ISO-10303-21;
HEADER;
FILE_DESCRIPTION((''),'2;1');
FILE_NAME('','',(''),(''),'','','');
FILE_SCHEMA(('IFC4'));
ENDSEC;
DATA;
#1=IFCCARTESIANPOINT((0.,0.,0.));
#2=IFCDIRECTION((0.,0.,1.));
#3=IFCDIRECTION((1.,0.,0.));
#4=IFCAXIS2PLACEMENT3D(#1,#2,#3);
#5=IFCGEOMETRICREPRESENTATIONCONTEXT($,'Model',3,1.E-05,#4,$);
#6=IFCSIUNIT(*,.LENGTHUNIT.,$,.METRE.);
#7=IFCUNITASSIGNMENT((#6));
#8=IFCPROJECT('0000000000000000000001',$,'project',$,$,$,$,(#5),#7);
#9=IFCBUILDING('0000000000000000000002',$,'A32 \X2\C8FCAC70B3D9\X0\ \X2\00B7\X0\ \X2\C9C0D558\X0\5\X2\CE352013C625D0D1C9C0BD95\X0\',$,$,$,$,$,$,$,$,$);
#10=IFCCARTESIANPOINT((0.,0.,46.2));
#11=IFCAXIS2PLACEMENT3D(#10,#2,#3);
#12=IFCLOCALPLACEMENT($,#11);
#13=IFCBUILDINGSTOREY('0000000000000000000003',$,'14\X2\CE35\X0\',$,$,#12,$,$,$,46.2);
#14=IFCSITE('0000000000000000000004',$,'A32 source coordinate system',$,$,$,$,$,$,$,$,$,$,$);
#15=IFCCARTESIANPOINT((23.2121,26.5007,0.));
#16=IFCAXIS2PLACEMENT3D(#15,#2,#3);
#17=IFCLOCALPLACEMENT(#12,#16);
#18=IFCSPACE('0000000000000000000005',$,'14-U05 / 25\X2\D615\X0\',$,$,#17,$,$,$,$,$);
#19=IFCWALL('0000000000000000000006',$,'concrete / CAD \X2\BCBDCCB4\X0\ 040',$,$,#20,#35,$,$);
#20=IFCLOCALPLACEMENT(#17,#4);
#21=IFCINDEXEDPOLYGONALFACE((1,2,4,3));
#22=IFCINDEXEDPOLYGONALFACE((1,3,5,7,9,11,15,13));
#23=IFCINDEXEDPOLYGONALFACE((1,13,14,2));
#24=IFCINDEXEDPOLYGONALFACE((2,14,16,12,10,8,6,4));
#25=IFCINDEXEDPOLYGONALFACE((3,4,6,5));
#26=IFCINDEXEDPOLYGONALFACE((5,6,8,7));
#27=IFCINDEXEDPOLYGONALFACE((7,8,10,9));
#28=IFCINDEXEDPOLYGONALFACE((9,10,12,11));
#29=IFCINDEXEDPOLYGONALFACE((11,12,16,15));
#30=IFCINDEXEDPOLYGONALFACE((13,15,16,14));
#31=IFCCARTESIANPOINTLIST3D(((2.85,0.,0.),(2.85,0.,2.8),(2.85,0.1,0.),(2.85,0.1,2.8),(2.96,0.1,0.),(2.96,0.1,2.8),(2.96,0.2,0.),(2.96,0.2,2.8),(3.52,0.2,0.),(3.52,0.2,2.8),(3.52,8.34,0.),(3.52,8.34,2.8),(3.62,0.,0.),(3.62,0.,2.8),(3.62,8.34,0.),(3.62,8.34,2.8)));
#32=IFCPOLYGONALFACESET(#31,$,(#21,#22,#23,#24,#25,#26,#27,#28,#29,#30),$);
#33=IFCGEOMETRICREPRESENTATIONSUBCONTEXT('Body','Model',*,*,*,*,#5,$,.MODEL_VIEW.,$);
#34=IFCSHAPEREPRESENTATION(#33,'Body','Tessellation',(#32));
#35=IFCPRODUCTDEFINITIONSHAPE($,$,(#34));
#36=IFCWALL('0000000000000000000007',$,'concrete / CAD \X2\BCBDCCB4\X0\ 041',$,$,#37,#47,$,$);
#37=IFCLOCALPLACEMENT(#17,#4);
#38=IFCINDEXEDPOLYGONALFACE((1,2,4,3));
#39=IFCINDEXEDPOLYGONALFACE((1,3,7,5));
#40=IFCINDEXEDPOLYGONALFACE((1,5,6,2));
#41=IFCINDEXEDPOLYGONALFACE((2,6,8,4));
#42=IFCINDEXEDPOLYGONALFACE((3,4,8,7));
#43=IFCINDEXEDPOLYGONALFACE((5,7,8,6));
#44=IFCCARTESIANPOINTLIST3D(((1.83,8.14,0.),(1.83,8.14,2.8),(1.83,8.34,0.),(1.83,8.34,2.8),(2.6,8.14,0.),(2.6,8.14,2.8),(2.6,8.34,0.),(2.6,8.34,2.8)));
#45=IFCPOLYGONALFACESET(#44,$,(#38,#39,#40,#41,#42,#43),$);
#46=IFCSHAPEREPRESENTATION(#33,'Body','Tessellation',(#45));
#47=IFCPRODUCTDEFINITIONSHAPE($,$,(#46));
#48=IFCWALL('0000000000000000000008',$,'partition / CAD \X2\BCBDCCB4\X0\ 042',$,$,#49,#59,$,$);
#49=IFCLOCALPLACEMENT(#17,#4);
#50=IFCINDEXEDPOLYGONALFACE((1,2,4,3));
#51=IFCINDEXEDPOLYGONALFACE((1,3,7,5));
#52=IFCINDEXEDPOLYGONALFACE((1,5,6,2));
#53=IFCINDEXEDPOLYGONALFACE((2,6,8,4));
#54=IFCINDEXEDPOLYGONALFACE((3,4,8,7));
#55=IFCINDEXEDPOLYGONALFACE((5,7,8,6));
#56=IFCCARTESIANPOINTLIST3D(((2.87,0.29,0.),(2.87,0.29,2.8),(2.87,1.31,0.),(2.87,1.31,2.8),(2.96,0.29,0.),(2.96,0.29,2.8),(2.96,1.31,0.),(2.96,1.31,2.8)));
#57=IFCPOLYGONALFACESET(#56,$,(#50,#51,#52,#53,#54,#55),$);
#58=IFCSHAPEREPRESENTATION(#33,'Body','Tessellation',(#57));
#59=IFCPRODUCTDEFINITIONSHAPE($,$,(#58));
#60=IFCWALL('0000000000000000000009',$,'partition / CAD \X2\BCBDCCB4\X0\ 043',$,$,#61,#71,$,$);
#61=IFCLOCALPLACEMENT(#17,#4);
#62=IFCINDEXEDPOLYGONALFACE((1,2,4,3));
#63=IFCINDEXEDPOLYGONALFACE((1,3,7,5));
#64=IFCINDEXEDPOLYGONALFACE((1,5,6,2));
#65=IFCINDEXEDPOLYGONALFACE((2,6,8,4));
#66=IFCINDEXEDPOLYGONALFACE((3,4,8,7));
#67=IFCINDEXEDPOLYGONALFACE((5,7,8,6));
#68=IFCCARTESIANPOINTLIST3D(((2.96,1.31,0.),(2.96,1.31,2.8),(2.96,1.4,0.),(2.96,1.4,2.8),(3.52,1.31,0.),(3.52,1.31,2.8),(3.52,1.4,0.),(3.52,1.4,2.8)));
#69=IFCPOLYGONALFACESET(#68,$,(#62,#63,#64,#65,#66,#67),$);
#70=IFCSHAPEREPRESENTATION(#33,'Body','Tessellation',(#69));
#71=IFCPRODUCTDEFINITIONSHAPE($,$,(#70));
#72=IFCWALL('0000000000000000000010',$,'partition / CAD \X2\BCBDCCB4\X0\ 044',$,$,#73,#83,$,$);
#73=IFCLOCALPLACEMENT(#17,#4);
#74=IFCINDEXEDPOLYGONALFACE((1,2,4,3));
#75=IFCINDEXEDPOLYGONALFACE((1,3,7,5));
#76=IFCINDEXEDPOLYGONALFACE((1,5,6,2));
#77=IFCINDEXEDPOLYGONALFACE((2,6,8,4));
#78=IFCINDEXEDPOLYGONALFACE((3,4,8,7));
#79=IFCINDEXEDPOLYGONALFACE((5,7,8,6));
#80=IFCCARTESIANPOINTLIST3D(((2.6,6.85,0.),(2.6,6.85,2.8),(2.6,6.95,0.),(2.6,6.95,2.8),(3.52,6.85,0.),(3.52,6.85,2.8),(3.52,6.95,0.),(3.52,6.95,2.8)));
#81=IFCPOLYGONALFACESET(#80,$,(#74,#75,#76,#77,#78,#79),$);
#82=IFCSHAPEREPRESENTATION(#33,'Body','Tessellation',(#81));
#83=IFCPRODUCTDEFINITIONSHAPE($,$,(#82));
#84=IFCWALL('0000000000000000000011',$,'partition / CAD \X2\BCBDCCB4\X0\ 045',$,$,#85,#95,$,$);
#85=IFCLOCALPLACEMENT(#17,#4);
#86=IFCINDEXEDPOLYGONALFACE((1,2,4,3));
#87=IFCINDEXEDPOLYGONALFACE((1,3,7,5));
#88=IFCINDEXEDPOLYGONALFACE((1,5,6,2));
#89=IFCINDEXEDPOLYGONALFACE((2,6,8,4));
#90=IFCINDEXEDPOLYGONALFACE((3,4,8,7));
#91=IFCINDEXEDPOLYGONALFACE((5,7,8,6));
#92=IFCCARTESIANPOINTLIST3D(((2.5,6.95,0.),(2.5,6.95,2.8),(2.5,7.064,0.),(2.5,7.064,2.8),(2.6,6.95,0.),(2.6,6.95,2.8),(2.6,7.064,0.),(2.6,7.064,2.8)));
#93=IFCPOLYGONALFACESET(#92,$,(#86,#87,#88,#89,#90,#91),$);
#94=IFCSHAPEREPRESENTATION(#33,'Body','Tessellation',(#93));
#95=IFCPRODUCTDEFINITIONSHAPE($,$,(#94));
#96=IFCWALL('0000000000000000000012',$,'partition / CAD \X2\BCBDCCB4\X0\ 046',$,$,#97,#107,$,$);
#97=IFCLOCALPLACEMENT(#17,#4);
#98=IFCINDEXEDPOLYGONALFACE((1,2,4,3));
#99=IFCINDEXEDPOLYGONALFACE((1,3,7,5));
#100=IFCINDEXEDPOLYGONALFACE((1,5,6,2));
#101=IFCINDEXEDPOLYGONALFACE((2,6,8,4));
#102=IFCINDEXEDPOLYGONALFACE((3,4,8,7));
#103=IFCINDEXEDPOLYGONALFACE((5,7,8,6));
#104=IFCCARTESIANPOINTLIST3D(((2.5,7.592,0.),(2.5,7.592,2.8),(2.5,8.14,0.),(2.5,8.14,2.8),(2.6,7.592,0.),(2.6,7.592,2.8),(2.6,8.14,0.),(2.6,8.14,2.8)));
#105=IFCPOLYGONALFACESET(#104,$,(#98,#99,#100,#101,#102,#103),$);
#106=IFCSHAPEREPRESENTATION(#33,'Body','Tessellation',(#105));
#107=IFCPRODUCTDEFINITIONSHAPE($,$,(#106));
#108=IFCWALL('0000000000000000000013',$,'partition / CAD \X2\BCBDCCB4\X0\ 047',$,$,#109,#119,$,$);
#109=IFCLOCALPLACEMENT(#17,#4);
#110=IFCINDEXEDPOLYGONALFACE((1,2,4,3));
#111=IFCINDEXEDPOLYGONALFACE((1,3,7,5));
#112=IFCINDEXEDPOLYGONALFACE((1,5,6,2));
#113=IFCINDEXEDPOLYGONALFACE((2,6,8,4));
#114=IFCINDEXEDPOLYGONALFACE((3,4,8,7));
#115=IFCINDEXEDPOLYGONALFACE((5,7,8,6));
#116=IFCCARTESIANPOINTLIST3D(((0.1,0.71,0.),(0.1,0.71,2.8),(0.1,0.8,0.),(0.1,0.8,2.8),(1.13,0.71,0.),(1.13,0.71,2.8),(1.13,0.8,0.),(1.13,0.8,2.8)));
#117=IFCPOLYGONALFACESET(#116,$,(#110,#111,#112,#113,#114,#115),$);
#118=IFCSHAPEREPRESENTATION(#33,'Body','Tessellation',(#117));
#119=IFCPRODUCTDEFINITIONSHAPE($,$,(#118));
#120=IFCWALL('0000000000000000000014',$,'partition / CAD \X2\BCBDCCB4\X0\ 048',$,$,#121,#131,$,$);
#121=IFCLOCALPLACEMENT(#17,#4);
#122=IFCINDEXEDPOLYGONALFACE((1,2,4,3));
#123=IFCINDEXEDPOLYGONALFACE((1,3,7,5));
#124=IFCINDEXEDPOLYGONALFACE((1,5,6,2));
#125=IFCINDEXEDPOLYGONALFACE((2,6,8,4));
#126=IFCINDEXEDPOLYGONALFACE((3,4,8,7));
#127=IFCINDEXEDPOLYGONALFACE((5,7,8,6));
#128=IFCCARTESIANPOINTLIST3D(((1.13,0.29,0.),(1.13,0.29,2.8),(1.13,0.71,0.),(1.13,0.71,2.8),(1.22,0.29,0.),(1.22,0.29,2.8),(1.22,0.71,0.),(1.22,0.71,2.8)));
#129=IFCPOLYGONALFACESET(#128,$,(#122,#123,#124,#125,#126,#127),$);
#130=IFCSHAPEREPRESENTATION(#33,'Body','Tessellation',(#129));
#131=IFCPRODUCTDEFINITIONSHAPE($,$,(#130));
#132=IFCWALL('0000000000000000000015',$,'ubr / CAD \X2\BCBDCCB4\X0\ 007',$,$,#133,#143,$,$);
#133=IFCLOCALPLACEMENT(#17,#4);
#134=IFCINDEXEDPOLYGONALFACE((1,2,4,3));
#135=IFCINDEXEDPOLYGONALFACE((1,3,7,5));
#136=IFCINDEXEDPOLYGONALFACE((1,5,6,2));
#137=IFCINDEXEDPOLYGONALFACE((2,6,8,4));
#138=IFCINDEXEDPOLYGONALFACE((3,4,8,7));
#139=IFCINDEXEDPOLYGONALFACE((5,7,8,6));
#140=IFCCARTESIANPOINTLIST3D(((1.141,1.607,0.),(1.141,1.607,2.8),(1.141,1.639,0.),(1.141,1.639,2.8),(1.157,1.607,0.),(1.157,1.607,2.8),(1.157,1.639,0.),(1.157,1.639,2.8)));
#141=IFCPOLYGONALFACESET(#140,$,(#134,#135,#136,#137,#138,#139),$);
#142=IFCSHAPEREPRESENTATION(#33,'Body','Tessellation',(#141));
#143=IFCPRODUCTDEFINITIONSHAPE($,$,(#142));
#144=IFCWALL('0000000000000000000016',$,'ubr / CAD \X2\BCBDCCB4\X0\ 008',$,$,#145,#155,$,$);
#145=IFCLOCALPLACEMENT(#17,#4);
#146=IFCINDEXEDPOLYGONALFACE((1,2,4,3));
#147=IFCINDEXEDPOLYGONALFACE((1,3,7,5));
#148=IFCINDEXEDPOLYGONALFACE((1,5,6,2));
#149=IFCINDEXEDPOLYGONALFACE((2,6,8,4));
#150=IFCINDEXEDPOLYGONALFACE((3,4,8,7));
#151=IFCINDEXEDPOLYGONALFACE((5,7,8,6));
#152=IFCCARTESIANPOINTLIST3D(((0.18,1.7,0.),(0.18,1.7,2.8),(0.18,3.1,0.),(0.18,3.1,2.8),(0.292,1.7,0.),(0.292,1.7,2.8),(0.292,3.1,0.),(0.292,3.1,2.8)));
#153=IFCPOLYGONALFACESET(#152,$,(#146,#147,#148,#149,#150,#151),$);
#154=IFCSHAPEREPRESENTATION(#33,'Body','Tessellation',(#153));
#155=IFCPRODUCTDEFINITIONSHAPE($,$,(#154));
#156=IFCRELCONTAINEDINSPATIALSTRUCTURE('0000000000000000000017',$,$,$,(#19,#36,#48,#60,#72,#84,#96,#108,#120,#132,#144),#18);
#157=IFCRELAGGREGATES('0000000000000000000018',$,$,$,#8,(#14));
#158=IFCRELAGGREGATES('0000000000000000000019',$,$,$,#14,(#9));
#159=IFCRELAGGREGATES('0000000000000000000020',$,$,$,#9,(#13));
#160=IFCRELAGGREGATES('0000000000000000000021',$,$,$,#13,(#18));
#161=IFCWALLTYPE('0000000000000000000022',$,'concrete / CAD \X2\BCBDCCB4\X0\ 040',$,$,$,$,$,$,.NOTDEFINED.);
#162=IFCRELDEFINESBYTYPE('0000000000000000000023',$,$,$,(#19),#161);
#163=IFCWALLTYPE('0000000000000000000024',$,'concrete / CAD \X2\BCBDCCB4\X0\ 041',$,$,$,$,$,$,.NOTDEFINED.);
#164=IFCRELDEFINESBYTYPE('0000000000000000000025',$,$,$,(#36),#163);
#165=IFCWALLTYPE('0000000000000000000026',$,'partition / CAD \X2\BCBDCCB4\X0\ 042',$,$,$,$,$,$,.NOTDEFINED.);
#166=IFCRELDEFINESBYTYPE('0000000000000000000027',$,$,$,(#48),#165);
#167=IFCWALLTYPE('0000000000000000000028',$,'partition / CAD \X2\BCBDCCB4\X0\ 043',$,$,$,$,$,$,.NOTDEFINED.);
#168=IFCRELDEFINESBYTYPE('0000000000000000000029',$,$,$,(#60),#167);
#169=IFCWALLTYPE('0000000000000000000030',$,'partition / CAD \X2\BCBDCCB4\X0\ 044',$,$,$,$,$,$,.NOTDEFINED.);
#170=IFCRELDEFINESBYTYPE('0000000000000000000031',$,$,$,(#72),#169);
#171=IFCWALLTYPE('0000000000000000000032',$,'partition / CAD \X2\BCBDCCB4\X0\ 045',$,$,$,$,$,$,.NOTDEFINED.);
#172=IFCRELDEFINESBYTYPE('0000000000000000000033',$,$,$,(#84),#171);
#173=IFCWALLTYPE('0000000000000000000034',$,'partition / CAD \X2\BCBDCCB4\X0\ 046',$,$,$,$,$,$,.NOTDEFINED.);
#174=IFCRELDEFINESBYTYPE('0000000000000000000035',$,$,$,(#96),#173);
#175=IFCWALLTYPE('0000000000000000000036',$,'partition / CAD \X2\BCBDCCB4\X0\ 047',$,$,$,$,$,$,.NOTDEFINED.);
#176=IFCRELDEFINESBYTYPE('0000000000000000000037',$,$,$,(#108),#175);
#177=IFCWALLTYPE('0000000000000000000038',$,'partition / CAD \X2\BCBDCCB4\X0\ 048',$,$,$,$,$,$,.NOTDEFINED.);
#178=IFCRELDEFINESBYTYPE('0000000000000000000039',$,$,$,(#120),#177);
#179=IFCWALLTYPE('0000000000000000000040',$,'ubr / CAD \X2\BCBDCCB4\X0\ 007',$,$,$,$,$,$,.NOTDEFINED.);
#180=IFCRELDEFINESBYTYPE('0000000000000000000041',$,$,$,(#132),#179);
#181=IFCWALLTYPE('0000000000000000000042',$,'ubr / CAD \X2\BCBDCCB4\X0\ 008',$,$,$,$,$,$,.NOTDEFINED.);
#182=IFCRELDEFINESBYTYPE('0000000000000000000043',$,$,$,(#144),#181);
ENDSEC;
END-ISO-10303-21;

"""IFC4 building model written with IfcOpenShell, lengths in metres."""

from ifc_helpers import new_model, si_unit, frame, origin, origin_with_axes, place, context, subcontext, project, spatial, polyline, outline, extrude, source, transform, mapped, type_object, type_shapes, element, save


model = new_model("IFC4")

# Units and contexts
model_context = context("Model", 3, precision=1e-05, world=origin_with_axes())
body_context = subcontext(model_context, "Body", "Model", "MODEL_VIEW")
ifc_project = project(units=[si_unit("LENGTHUNIT", "METRE")], contexts=[model_context])

# Site, building, storey, space
site = spatial("IfcSite", under=ifc_project, Name="A32 source coordinate system")
building = spatial("IfcBuilding", under=site, Name="A32 주거동 · 지하5층–옥탑지붕")
storey_placement = place(None, frame((0.0, 0.0, 46.2), z_axis=(0.0, 0.0, 1.0), x_axis=(1.0, 0.0, 0.0)))
storey = spatial("IfcBuildingStorey", under=building, at=storey_placement, Name="14층", Elevation=46.2)
space_1_placement = place(storey_placement, frame((23.2121, 26.5007, 0.0), z_axis=(0.0, 0.0, 1.0), x_axis=(1.0, 0.0, 0.0)))
space_1 = spatial("IfcSpace", under=storey, at=space_1_placement, Name="14-U05 / 25형")

# Walls
wall_type_1 = type_object("IfcWallType", Name="concrete / CAD 벽체 040", PredefinedType="NOTDEFINED")
shared_shape_1 = source(origin(), body_context, "Body", "SweptSolid", [
    extrude(outline(polyline([(3.62, 8.34), (3.62, 0.0), (2.85, 0.0), (2.85, 0.1), (2.96, 0.1), (2.96, 0.2), (3.52, 0.2), (3.52, 8.34), (3.62, 8.34)])), origin(), (0.0, 0.0, 1.0), 2.8),
])
type_shapes(wall_type_1, [shared_shape_1])
wall_1_placement = place(space_1_placement, origin_with_axes())
element("IfcWall", 1, at=wall_1_placement, inside=space_1, type_object=wall_type_1, Name="concrete / CAD 벽체 040", context=body_context, shape_type="MappedRepresentation", body=[
    mapped(shared_shape_1, transform((0.0, 0.0, 0.0), scale=1.0)),
])
wall_type_2 = type_object("IfcWallType", Name="concrete / CAD 벽체 041", PredefinedType="NOTDEFINED")
shared_shape_2 = source(origin(), body_context, "Body", "SweptSolid", [
    extrude(outline(polyline([(2.6, 8.14), (1.83, 8.14), (1.83, 8.34), (2.6, 8.34), (2.6, 8.14)])), origin(), (0.0, 0.0, 1.0), 2.8),
])
type_shapes(wall_type_2, [shared_shape_2])
wall_2_placement = place(space_1_placement, origin_with_axes())
element("IfcWall", 2, at=wall_2_placement, inside=space_1, type_object=wall_type_2, Name="concrete / CAD 벽체 041", context=body_context, shape_type="MappedRepresentation", body=[
    mapped(shared_shape_2, transform((0.0, 0.0, 0.0), scale=1.0)),
])
wall_type_3 = type_object("IfcWallType", Name="partition / CAD 벽체 042", PredefinedType="NOTDEFINED")
shared_shape_3 = source(origin(), body_context, "Body", "SweptSolid", [
    extrude(outline(polyline([(2.87, 1.31), (2.96, 1.31), (2.96, 0.29), (2.87, 0.29), (2.87, 1.31)])), origin(), (0.0, 0.0, 1.0), 2.8),
])
type_shapes(wall_type_3, [shared_shape_3])
wall_3_placement = place(space_1_placement, origin_with_axes())
element("IfcWall", 3, at=wall_3_placement, inside=space_1, type_object=wall_type_3, Name="partition / CAD 벽체 042", context=body_context, shape_type="MappedRepresentation", body=[
    mapped(shared_shape_3, transform((0.0, 0.0, 0.0), scale=1.0)),
])
wall_type_4 = type_object("IfcWallType", Name="partition / CAD 벽체 043", PredefinedType="NOTDEFINED")
shared_shape_4 = source(origin(), body_context, "Body", "SweptSolid", [
    extrude(outline(polyline([(3.52, 1.4), (3.52, 1.31), (2.96, 1.31), (2.96, 1.4), (3.52, 1.4)])), origin(), (0.0, 0.0, 1.0), 2.8),
])
type_shapes(wall_type_4, [shared_shape_4])
wall_4_placement = place(space_1_placement, origin_with_axes())
element("IfcWall", 4, at=wall_4_placement, inside=space_1, type_object=wall_type_4, Name="partition / CAD 벽체 043", context=body_context, shape_type="MappedRepresentation", body=[
    mapped(shared_shape_4, transform((0.0, 0.0, 0.0), scale=1.0)),
])
wall_type_5 = type_object("IfcWallType", Name="partition / CAD 벽체 044", PredefinedType="NOTDEFINED")
shared_shape_5 = source(origin(), body_context, "Body", "SweptSolid", [
    extrude(outline(polyline([(3.52, 6.95), (3.52, 6.85), (2.6, 6.85), (2.6, 6.95), (3.52, 6.95)])), origin(), (0.0, 0.0, 1.0), 2.8),
])
type_shapes(wall_type_5, [shared_shape_5])
wall_5_placement = place(space_1_placement, origin_with_axes())
element("IfcWall", 5, at=wall_5_placement, inside=space_1, type_object=wall_type_5, Name="partition / CAD 벽체 044", context=body_context, shape_type="MappedRepresentation", body=[
    mapped(shared_shape_5, transform((0.0, 0.0, 0.0), scale=1.0)),
])
wall_type_6 = type_object("IfcWallType", Name="partition / CAD 벽체 045", PredefinedType="NOTDEFINED")
shared_shape_6 = source(origin(), body_context, "Body", "SweptSolid", [
    extrude(outline(polyline([(2.5, 7.064), (2.6, 7.064), (2.6, 6.95), (2.5, 6.95), (2.5, 7.064)])), origin(), (0.0, 0.0, 1.0), 2.8),
])
type_shapes(wall_type_6, [shared_shape_6])
wall_6_placement = place(space_1_placement, origin_with_axes())
element("IfcWall", 6, at=wall_6_placement, inside=space_1, type_object=wall_type_6, Name="partition / CAD 벽체 045", context=body_context, shape_type="MappedRepresentation", body=[
    mapped(shared_shape_6, transform((0.0, 0.0, 0.0), scale=1.0)),
])
wall_type_7 = type_object("IfcWallType", Name="partition / CAD 벽체 046", PredefinedType="NOTDEFINED")
shared_shape_7 = source(origin(), body_context, "Body", "SweptSolid", [
    extrude(outline(polyline([(2.6, 7.592), (2.5, 7.592), (2.5, 8.14), (2.6, 8.14), (2.6, 7.592)])), origin(), (0.0, 0.0, 1.0), 2.8),
])
type_shapes(wall_type_7, [shared_shape_7])
wall_7_placement = place(space_1_placement, origin_with_axes())
element("IfcWall", 7, at=wall_7_placement, inside=space_1, type_object=wall_type_7, Name="partition / CAD 벽체 046", context=body_context, shape_type="MappedRepresentation", body=[
    mapped(shared_shape_7, transform((0.0, 0.0, 0.0), scale=1.0)),
])
wall_type_8 = type_object("IfcWallType", Name="partition / CAD 벽체 047", PredefinedType="NOTDEFINED")
shared_shape_8 = source(origin(), body_context, "Body", "SweptSolid", [
    extrude(outline(polyline([(1.13, 0.71), (0.1, 0.71), (0.1, 0.8), (1.13, 0.8), (1.13, 0.71)])), origin(), (0.0, 0.0, 1.0), 2.8),
])
type_shapes(wall_type_8, [shared_shape_8])
wall_8_placement = place(space_1_placement, origin_with_axes())
element("IfcWall", 8, at=wall_8_placement, inside=space_1, type_object=wall_type_8, Name="partition / CAD 벽체 047", context=body_context, shape_type="MappedRepresentation", body=[
    mapped(shared_shape_8, transform((0.0, 0.0, 0.0), scale=1.0)),
])
wall_type_9 = type_object("IfcWallType", Name="partition / CAD 벽체 048", PredefinedType="NOTDEFINED")
shared_shape_9 = source(origin(), body_context, "Body", "SweptSolid", [
    extrude(outline(polyline([(1.22, 0.29), (1.13, 0.29), (1.13, 0.71), (1.22, 0.71), (1.22, 0.29)])), origin(), (0.0, 0.0, 1.0), 2.8),
])
type_shapes(wall_type_9, [shared_shape_9])
wall_9_placement = place(space_1_placement, origin_with_axes())
element("IfcWall", 9, at=wall_9_placement, inside=space_1, type_object=wall_type_9, Name="partition / CAD 벽체 048", context=body_context, shape_type="MappedRepresentation", body=[
    mapped(shared_shape_9, transform((0.0, 0.0, 0.0), scale=1.0)),
])
wall_type_10 = type_object("IfcWallType", Name="ubr / CAD 벽체 007", PredefinedType="NOTDEFINED")
shared_shape_10 = source(origin(), body_context, "Body", "SweptSolid", [
    extrude(outline(polyline([(1.157, 1.607), (1.141, 1.607), (1.141, 1.639), (1.157, 1.639), (1.157, 1.607)])), origin(), (0.0, 0.0, 1.0), 2.8),
])
type_shapes(wall_type_10, [shared_shape_10])
wall_10_placement = place(space_1_placement, origin_with_axes())
element("IfcWall", 10, at=wall_10_placement, inside=space_1, type_object=wall_type_10, Name="ubr / CAD 벽체 007", context=body_context, shape_type="MappedRepresentation", body=[
    mapped(shared_shape_10, transform((0.0, 0.0, 0.0), scale=1.0)),
])
wall_type_11 = type_object("IfcWallType", Name="ubr / CAD 벽체 008", PredefinedType="NOTDEFINED")
shared_shape_11 = source(origin(), body_context, "Body", "SweptSolid", [
    extrude(outline(polyline([(0.292, 1.7), (0.18, 1.7), (0.18, 3.1), (0.292, 3.1), (0.292, 1.7)])), origin(), (0.0, 0.0, 1.0), 2.8),
])
type_shapes(wall_type_11, [shared_shape_11])
wall_11_placement = place(space_1_placement, origin_with_axes())
element("IfcWall", 11, at=wall_11_placement, inside=space_1, type_object=wall_type_11, Name="ubr / CAD 벽체 008", context=body_context, shape_type="MappedRepresentation", body=[
    mapped(shared_shape_11, transform((0.0, 0.0, 0.0), scale=1.0)),
])

save(model, "model.ifc")
